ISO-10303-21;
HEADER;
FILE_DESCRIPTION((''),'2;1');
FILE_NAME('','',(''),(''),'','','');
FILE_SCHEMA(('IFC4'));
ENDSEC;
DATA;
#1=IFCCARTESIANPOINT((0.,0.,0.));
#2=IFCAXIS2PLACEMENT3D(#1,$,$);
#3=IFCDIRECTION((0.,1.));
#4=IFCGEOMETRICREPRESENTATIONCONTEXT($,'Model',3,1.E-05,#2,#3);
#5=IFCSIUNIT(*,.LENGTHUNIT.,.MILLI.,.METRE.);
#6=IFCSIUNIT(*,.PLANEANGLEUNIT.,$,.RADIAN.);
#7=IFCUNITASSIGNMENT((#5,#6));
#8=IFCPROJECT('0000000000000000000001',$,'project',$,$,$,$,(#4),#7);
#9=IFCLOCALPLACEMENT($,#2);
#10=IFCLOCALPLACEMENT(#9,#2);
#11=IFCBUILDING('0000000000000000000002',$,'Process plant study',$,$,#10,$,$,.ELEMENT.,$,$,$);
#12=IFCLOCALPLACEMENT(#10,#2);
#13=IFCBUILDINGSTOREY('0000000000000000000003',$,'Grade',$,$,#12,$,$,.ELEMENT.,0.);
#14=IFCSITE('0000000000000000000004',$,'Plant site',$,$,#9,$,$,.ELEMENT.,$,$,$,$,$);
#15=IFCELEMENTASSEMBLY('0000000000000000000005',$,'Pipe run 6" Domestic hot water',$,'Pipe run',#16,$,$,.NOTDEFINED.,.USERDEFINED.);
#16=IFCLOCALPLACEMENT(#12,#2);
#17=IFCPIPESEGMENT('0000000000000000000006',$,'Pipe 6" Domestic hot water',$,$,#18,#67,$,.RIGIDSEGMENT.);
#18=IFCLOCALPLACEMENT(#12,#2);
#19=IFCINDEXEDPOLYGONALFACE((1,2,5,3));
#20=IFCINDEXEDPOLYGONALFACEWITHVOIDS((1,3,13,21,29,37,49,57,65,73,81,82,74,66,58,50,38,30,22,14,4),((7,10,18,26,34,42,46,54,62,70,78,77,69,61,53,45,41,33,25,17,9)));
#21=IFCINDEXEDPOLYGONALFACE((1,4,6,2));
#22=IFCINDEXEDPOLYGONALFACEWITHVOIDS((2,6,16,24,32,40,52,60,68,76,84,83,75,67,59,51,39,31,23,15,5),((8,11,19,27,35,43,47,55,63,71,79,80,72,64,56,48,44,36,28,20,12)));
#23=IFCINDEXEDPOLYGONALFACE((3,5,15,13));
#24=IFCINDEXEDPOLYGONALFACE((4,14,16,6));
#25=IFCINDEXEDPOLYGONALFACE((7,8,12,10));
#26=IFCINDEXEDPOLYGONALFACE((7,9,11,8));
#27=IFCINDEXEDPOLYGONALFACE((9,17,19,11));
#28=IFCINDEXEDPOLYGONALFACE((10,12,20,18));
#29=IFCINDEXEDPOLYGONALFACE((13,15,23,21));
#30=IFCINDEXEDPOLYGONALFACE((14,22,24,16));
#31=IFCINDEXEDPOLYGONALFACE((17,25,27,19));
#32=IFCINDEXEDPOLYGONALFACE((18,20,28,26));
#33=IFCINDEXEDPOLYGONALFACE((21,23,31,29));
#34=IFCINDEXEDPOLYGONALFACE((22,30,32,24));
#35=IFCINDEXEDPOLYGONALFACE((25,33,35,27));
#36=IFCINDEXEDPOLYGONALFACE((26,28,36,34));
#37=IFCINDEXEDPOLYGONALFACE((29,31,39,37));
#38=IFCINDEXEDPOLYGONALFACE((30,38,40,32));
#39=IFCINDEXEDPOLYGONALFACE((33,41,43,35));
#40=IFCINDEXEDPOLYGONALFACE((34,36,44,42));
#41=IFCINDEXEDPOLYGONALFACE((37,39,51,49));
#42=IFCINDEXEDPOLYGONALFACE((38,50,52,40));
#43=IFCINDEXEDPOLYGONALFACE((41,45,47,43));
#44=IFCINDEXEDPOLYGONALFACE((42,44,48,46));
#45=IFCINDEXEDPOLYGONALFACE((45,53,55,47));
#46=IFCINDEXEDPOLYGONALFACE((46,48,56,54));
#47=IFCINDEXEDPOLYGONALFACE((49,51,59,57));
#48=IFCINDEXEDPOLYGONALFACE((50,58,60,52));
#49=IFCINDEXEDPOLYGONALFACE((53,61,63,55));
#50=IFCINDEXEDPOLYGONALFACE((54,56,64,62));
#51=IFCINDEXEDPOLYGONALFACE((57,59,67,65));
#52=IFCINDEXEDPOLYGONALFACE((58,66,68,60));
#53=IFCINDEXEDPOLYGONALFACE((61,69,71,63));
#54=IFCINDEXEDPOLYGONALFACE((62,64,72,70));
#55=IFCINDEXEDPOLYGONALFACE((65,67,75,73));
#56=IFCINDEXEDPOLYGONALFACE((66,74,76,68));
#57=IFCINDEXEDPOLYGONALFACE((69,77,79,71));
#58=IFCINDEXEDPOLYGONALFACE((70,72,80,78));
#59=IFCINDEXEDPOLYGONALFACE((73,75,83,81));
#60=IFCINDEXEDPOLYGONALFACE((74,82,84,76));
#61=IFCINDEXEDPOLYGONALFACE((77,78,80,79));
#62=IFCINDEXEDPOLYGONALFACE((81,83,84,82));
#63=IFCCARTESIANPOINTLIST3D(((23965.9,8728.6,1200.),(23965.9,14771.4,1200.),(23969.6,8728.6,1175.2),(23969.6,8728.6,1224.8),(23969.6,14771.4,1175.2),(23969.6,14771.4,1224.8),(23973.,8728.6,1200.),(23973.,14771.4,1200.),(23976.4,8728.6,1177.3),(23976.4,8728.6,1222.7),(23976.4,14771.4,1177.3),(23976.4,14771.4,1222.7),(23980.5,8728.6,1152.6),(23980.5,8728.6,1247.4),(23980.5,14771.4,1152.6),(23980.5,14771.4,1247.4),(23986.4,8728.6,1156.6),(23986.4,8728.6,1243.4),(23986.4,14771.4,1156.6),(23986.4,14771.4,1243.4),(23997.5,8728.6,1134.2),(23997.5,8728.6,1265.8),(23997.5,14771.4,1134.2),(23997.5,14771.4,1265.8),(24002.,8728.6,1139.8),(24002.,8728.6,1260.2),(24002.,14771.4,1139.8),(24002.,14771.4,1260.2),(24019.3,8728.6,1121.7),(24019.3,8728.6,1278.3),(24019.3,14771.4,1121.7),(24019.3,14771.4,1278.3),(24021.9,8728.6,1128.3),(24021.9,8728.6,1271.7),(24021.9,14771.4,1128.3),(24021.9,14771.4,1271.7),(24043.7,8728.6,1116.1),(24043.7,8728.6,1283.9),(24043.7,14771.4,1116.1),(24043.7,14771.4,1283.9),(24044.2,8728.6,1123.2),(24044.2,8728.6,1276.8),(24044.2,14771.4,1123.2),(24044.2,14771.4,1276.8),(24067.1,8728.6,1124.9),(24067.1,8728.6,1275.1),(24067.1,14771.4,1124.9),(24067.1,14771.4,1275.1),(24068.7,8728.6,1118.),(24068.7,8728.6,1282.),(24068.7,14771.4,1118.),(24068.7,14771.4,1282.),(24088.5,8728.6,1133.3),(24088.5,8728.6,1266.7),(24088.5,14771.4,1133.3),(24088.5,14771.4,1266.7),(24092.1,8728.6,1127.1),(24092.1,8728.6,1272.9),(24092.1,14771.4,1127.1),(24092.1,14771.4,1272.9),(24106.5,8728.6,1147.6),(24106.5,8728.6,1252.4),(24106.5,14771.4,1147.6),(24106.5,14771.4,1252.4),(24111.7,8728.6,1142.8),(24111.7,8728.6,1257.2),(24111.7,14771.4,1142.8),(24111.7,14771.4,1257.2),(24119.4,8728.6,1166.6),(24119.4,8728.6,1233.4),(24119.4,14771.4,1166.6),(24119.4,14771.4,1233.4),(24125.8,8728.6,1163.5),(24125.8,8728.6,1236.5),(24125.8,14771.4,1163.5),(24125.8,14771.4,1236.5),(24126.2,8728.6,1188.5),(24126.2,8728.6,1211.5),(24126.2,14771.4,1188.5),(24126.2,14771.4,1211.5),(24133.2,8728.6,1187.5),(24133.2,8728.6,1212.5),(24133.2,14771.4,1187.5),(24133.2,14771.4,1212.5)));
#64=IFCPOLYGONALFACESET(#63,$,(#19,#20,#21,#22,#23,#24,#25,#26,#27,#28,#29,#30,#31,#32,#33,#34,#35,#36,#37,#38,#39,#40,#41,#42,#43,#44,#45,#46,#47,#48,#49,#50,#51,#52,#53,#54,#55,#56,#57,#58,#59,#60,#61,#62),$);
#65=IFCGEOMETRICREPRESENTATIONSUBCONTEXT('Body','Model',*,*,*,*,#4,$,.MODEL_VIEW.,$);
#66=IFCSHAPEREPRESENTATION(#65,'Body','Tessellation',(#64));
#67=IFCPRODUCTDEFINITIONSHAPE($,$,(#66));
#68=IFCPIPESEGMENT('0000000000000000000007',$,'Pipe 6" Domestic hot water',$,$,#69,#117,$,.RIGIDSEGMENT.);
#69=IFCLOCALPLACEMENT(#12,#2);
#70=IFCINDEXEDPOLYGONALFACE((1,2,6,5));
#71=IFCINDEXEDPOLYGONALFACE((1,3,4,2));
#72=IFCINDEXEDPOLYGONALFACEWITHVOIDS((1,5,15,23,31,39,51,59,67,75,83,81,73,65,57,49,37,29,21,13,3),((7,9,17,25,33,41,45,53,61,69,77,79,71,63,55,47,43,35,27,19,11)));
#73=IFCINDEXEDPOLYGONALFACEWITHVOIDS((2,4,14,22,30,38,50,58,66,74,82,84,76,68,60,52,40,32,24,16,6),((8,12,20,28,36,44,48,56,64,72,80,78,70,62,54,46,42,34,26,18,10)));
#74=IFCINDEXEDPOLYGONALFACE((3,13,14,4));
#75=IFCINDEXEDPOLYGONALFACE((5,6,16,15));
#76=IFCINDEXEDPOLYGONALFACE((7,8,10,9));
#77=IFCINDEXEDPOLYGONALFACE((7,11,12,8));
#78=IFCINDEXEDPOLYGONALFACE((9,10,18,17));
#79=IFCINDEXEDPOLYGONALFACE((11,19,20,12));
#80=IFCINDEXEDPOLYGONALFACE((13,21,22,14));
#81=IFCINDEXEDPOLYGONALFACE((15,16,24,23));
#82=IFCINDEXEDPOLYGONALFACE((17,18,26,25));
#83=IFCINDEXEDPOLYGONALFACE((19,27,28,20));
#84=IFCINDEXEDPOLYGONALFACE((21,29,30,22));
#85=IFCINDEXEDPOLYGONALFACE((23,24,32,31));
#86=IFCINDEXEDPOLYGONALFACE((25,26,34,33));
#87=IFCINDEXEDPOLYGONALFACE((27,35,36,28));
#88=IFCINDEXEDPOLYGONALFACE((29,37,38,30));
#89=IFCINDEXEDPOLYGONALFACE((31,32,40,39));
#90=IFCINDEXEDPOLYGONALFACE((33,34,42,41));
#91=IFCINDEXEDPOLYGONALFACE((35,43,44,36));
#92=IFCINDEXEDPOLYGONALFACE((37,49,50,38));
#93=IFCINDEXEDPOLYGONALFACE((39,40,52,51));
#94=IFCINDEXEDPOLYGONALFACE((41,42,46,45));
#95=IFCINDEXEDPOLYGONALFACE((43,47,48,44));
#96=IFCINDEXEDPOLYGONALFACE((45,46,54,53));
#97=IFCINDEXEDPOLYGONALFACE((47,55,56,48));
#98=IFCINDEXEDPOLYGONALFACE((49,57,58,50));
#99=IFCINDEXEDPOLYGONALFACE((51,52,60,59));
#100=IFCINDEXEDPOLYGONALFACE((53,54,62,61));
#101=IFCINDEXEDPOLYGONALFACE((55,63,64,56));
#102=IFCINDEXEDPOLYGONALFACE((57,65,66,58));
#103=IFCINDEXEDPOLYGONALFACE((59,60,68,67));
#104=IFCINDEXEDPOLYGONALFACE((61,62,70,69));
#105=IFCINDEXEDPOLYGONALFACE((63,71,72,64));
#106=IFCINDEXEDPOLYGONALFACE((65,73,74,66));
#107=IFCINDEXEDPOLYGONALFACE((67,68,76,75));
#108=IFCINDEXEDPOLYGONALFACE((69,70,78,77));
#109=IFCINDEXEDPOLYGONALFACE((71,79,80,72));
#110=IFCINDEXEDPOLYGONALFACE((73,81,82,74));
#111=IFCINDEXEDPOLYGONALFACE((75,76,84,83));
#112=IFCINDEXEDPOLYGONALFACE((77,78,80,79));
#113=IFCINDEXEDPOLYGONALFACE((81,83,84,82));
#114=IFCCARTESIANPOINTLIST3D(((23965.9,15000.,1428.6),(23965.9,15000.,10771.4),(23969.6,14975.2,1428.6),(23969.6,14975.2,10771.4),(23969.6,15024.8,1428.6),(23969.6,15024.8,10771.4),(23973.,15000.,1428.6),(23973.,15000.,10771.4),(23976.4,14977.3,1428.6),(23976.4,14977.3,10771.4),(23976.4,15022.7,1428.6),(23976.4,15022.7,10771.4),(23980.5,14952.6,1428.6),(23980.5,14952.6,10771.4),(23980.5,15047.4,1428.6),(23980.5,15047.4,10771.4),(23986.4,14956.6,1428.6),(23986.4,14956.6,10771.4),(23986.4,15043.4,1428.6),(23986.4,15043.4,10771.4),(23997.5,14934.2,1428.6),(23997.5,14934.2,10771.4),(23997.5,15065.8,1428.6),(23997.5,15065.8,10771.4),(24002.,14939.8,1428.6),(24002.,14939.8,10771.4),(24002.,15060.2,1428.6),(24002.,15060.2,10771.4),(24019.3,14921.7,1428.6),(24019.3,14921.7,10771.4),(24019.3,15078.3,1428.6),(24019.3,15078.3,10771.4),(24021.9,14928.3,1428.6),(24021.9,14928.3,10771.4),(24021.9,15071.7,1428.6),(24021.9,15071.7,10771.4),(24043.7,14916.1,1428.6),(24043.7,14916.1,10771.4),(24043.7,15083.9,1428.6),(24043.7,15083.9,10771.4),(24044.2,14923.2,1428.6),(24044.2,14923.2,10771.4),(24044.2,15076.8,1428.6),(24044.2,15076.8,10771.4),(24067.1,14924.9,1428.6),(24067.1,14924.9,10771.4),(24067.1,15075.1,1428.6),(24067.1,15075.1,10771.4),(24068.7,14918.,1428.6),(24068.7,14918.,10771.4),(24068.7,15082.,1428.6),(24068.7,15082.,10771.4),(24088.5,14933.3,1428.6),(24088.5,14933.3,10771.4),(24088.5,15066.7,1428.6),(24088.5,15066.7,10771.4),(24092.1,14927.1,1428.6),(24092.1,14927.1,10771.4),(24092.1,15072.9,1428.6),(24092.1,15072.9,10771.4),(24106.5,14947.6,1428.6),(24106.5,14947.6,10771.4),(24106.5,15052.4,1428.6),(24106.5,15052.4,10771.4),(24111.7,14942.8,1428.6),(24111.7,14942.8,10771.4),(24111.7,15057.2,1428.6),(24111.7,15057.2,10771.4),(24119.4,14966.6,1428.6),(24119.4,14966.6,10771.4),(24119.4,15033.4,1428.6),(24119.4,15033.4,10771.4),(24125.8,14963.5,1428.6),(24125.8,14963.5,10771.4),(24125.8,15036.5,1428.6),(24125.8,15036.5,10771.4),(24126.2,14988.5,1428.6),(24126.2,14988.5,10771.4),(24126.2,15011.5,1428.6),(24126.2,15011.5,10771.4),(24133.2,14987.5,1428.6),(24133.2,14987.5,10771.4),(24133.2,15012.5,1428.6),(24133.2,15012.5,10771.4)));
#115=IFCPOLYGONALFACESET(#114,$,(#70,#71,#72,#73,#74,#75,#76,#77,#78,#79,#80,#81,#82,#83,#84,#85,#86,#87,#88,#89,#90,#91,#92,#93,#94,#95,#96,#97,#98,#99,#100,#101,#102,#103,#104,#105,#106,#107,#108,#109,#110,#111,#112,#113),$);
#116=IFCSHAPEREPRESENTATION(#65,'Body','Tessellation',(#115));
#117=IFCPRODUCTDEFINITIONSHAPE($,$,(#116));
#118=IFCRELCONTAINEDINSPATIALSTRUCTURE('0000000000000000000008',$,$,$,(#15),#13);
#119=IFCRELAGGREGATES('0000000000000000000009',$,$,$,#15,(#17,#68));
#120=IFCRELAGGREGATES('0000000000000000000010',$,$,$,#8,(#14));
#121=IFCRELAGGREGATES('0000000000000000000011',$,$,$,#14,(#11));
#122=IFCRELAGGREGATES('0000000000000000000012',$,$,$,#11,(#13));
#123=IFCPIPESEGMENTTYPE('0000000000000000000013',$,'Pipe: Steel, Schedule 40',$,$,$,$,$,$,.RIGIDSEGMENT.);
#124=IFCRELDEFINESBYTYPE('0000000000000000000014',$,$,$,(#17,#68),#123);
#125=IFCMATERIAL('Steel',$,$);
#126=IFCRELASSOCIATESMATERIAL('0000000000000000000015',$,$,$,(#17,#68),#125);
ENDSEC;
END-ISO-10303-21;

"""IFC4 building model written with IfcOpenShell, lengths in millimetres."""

from ifc_helpers import new_model, si_unit, direction, frame, origin, origin_with_axes, origin_2d, place, context, subcontext, project, spatial, hollow_circle, extrude, material, type_object, element, aggregate, save


model = new_model("IFC4")

# Units and contexts
model_context = context("Model", 3, precision=1e-05, world=origin(), true_north=direction((0.0, 1.0)))
body_context = subcontext(model_context, "Body", "Model", "MODEL_VIEW")
ifc_project = project(units=[si_unit("LENGTHUNIT", "METRE", prefix="MILLI"), si_unit("PLANEANGLEUNIT", "RADIAN")], contexts=[model_context])

# Site, building, storey
site_placement = place(None, origin())
site = spatial("IfcSite", under=ifc_project, at=site_placement, Name="Plant site", CompositionType="ELEMENT")
building_placement = place(site_placement, origin())
building = spatial("IfcBuilding", under=site, at=building_placement, Name="Process plant study", CompositionType="ELEMENT")
storey_placement = place(building_placement, origin())
storey = spatial("IfcBuildingStorey", under=building, at=storey_placement, Name="Grade", CompositionType="ELEMENT", Elevation=0.0)

# Element assembly, pipe segments
ifc_material = material(Name="Steel")
pipe_segment_type = type_object("IfcPipeSegmentType", Name="Pipe: Steel, Schedule 40", PredefinedType="RIGIDSEGMENT")
assembly_1_placement = place(storey_placement, origin_with_axes())
assembly_1 = element("IfcElementAssembly", 1, at=assembly_1_placement, inside=storey, Name="Pipe run 6\" Domestic hot water", ObjectType="Pipe run", AssemblyPlace="NOTDEFINED", PredefinedType="USERDEFINED")
pipe_segment_1_placement = place(storey_placement, origin_with_axes())
pipe_segment_1 = element("IfcPipeSegment", 2, at=pipe_segment_1_placement, type_object=pipe_segment_type, material=ifc_material, Name="Pipe 6\" Domestic hot water", PredefinedType="RIGIDSEGMENT", context=body_context, shape_type="SweptSolid", body=[
    extrude(hollow_circle(Radius=84.1, WallThickness=7.1, at=origin_2d()), frame((24050.0, 8728.6, 1200.0), z_axis=(0.0, 1.0, 0.0), x_axis=(-1.0, 0.0, 0.0)), (0.0, 0.0, 1.0), 6042.8),
])
pipe_segment_2_placement = place(storey_placement, origin_with_axes())
pipe_segment_2 = element("IfcPipeSegment", 3, at=pipe_segment_2_placement, type_object=pipe_segment_type, material=ifc_material, Name="Pipe 6\" Domestic hot water", PredefinedType="RIGIDSEGMENT", context=body_context, shape_type="SweptSolid", body=[
    extrude(hollow_circle(Radius=84.1, WallThickness=7.1, at=origin_2d()), frame((24050.0, 15000.0, 1428.6), z_axis=(0.0, 0.0, 1.0), x_axis=(-1.0, 0.0, 0.0)), (0.0, 0.0, 1.0), 9342.8),
])

aggregate(assembly_1, [pipe_segment_1, pipe_segment_2])

save(model, "model.ifc")
